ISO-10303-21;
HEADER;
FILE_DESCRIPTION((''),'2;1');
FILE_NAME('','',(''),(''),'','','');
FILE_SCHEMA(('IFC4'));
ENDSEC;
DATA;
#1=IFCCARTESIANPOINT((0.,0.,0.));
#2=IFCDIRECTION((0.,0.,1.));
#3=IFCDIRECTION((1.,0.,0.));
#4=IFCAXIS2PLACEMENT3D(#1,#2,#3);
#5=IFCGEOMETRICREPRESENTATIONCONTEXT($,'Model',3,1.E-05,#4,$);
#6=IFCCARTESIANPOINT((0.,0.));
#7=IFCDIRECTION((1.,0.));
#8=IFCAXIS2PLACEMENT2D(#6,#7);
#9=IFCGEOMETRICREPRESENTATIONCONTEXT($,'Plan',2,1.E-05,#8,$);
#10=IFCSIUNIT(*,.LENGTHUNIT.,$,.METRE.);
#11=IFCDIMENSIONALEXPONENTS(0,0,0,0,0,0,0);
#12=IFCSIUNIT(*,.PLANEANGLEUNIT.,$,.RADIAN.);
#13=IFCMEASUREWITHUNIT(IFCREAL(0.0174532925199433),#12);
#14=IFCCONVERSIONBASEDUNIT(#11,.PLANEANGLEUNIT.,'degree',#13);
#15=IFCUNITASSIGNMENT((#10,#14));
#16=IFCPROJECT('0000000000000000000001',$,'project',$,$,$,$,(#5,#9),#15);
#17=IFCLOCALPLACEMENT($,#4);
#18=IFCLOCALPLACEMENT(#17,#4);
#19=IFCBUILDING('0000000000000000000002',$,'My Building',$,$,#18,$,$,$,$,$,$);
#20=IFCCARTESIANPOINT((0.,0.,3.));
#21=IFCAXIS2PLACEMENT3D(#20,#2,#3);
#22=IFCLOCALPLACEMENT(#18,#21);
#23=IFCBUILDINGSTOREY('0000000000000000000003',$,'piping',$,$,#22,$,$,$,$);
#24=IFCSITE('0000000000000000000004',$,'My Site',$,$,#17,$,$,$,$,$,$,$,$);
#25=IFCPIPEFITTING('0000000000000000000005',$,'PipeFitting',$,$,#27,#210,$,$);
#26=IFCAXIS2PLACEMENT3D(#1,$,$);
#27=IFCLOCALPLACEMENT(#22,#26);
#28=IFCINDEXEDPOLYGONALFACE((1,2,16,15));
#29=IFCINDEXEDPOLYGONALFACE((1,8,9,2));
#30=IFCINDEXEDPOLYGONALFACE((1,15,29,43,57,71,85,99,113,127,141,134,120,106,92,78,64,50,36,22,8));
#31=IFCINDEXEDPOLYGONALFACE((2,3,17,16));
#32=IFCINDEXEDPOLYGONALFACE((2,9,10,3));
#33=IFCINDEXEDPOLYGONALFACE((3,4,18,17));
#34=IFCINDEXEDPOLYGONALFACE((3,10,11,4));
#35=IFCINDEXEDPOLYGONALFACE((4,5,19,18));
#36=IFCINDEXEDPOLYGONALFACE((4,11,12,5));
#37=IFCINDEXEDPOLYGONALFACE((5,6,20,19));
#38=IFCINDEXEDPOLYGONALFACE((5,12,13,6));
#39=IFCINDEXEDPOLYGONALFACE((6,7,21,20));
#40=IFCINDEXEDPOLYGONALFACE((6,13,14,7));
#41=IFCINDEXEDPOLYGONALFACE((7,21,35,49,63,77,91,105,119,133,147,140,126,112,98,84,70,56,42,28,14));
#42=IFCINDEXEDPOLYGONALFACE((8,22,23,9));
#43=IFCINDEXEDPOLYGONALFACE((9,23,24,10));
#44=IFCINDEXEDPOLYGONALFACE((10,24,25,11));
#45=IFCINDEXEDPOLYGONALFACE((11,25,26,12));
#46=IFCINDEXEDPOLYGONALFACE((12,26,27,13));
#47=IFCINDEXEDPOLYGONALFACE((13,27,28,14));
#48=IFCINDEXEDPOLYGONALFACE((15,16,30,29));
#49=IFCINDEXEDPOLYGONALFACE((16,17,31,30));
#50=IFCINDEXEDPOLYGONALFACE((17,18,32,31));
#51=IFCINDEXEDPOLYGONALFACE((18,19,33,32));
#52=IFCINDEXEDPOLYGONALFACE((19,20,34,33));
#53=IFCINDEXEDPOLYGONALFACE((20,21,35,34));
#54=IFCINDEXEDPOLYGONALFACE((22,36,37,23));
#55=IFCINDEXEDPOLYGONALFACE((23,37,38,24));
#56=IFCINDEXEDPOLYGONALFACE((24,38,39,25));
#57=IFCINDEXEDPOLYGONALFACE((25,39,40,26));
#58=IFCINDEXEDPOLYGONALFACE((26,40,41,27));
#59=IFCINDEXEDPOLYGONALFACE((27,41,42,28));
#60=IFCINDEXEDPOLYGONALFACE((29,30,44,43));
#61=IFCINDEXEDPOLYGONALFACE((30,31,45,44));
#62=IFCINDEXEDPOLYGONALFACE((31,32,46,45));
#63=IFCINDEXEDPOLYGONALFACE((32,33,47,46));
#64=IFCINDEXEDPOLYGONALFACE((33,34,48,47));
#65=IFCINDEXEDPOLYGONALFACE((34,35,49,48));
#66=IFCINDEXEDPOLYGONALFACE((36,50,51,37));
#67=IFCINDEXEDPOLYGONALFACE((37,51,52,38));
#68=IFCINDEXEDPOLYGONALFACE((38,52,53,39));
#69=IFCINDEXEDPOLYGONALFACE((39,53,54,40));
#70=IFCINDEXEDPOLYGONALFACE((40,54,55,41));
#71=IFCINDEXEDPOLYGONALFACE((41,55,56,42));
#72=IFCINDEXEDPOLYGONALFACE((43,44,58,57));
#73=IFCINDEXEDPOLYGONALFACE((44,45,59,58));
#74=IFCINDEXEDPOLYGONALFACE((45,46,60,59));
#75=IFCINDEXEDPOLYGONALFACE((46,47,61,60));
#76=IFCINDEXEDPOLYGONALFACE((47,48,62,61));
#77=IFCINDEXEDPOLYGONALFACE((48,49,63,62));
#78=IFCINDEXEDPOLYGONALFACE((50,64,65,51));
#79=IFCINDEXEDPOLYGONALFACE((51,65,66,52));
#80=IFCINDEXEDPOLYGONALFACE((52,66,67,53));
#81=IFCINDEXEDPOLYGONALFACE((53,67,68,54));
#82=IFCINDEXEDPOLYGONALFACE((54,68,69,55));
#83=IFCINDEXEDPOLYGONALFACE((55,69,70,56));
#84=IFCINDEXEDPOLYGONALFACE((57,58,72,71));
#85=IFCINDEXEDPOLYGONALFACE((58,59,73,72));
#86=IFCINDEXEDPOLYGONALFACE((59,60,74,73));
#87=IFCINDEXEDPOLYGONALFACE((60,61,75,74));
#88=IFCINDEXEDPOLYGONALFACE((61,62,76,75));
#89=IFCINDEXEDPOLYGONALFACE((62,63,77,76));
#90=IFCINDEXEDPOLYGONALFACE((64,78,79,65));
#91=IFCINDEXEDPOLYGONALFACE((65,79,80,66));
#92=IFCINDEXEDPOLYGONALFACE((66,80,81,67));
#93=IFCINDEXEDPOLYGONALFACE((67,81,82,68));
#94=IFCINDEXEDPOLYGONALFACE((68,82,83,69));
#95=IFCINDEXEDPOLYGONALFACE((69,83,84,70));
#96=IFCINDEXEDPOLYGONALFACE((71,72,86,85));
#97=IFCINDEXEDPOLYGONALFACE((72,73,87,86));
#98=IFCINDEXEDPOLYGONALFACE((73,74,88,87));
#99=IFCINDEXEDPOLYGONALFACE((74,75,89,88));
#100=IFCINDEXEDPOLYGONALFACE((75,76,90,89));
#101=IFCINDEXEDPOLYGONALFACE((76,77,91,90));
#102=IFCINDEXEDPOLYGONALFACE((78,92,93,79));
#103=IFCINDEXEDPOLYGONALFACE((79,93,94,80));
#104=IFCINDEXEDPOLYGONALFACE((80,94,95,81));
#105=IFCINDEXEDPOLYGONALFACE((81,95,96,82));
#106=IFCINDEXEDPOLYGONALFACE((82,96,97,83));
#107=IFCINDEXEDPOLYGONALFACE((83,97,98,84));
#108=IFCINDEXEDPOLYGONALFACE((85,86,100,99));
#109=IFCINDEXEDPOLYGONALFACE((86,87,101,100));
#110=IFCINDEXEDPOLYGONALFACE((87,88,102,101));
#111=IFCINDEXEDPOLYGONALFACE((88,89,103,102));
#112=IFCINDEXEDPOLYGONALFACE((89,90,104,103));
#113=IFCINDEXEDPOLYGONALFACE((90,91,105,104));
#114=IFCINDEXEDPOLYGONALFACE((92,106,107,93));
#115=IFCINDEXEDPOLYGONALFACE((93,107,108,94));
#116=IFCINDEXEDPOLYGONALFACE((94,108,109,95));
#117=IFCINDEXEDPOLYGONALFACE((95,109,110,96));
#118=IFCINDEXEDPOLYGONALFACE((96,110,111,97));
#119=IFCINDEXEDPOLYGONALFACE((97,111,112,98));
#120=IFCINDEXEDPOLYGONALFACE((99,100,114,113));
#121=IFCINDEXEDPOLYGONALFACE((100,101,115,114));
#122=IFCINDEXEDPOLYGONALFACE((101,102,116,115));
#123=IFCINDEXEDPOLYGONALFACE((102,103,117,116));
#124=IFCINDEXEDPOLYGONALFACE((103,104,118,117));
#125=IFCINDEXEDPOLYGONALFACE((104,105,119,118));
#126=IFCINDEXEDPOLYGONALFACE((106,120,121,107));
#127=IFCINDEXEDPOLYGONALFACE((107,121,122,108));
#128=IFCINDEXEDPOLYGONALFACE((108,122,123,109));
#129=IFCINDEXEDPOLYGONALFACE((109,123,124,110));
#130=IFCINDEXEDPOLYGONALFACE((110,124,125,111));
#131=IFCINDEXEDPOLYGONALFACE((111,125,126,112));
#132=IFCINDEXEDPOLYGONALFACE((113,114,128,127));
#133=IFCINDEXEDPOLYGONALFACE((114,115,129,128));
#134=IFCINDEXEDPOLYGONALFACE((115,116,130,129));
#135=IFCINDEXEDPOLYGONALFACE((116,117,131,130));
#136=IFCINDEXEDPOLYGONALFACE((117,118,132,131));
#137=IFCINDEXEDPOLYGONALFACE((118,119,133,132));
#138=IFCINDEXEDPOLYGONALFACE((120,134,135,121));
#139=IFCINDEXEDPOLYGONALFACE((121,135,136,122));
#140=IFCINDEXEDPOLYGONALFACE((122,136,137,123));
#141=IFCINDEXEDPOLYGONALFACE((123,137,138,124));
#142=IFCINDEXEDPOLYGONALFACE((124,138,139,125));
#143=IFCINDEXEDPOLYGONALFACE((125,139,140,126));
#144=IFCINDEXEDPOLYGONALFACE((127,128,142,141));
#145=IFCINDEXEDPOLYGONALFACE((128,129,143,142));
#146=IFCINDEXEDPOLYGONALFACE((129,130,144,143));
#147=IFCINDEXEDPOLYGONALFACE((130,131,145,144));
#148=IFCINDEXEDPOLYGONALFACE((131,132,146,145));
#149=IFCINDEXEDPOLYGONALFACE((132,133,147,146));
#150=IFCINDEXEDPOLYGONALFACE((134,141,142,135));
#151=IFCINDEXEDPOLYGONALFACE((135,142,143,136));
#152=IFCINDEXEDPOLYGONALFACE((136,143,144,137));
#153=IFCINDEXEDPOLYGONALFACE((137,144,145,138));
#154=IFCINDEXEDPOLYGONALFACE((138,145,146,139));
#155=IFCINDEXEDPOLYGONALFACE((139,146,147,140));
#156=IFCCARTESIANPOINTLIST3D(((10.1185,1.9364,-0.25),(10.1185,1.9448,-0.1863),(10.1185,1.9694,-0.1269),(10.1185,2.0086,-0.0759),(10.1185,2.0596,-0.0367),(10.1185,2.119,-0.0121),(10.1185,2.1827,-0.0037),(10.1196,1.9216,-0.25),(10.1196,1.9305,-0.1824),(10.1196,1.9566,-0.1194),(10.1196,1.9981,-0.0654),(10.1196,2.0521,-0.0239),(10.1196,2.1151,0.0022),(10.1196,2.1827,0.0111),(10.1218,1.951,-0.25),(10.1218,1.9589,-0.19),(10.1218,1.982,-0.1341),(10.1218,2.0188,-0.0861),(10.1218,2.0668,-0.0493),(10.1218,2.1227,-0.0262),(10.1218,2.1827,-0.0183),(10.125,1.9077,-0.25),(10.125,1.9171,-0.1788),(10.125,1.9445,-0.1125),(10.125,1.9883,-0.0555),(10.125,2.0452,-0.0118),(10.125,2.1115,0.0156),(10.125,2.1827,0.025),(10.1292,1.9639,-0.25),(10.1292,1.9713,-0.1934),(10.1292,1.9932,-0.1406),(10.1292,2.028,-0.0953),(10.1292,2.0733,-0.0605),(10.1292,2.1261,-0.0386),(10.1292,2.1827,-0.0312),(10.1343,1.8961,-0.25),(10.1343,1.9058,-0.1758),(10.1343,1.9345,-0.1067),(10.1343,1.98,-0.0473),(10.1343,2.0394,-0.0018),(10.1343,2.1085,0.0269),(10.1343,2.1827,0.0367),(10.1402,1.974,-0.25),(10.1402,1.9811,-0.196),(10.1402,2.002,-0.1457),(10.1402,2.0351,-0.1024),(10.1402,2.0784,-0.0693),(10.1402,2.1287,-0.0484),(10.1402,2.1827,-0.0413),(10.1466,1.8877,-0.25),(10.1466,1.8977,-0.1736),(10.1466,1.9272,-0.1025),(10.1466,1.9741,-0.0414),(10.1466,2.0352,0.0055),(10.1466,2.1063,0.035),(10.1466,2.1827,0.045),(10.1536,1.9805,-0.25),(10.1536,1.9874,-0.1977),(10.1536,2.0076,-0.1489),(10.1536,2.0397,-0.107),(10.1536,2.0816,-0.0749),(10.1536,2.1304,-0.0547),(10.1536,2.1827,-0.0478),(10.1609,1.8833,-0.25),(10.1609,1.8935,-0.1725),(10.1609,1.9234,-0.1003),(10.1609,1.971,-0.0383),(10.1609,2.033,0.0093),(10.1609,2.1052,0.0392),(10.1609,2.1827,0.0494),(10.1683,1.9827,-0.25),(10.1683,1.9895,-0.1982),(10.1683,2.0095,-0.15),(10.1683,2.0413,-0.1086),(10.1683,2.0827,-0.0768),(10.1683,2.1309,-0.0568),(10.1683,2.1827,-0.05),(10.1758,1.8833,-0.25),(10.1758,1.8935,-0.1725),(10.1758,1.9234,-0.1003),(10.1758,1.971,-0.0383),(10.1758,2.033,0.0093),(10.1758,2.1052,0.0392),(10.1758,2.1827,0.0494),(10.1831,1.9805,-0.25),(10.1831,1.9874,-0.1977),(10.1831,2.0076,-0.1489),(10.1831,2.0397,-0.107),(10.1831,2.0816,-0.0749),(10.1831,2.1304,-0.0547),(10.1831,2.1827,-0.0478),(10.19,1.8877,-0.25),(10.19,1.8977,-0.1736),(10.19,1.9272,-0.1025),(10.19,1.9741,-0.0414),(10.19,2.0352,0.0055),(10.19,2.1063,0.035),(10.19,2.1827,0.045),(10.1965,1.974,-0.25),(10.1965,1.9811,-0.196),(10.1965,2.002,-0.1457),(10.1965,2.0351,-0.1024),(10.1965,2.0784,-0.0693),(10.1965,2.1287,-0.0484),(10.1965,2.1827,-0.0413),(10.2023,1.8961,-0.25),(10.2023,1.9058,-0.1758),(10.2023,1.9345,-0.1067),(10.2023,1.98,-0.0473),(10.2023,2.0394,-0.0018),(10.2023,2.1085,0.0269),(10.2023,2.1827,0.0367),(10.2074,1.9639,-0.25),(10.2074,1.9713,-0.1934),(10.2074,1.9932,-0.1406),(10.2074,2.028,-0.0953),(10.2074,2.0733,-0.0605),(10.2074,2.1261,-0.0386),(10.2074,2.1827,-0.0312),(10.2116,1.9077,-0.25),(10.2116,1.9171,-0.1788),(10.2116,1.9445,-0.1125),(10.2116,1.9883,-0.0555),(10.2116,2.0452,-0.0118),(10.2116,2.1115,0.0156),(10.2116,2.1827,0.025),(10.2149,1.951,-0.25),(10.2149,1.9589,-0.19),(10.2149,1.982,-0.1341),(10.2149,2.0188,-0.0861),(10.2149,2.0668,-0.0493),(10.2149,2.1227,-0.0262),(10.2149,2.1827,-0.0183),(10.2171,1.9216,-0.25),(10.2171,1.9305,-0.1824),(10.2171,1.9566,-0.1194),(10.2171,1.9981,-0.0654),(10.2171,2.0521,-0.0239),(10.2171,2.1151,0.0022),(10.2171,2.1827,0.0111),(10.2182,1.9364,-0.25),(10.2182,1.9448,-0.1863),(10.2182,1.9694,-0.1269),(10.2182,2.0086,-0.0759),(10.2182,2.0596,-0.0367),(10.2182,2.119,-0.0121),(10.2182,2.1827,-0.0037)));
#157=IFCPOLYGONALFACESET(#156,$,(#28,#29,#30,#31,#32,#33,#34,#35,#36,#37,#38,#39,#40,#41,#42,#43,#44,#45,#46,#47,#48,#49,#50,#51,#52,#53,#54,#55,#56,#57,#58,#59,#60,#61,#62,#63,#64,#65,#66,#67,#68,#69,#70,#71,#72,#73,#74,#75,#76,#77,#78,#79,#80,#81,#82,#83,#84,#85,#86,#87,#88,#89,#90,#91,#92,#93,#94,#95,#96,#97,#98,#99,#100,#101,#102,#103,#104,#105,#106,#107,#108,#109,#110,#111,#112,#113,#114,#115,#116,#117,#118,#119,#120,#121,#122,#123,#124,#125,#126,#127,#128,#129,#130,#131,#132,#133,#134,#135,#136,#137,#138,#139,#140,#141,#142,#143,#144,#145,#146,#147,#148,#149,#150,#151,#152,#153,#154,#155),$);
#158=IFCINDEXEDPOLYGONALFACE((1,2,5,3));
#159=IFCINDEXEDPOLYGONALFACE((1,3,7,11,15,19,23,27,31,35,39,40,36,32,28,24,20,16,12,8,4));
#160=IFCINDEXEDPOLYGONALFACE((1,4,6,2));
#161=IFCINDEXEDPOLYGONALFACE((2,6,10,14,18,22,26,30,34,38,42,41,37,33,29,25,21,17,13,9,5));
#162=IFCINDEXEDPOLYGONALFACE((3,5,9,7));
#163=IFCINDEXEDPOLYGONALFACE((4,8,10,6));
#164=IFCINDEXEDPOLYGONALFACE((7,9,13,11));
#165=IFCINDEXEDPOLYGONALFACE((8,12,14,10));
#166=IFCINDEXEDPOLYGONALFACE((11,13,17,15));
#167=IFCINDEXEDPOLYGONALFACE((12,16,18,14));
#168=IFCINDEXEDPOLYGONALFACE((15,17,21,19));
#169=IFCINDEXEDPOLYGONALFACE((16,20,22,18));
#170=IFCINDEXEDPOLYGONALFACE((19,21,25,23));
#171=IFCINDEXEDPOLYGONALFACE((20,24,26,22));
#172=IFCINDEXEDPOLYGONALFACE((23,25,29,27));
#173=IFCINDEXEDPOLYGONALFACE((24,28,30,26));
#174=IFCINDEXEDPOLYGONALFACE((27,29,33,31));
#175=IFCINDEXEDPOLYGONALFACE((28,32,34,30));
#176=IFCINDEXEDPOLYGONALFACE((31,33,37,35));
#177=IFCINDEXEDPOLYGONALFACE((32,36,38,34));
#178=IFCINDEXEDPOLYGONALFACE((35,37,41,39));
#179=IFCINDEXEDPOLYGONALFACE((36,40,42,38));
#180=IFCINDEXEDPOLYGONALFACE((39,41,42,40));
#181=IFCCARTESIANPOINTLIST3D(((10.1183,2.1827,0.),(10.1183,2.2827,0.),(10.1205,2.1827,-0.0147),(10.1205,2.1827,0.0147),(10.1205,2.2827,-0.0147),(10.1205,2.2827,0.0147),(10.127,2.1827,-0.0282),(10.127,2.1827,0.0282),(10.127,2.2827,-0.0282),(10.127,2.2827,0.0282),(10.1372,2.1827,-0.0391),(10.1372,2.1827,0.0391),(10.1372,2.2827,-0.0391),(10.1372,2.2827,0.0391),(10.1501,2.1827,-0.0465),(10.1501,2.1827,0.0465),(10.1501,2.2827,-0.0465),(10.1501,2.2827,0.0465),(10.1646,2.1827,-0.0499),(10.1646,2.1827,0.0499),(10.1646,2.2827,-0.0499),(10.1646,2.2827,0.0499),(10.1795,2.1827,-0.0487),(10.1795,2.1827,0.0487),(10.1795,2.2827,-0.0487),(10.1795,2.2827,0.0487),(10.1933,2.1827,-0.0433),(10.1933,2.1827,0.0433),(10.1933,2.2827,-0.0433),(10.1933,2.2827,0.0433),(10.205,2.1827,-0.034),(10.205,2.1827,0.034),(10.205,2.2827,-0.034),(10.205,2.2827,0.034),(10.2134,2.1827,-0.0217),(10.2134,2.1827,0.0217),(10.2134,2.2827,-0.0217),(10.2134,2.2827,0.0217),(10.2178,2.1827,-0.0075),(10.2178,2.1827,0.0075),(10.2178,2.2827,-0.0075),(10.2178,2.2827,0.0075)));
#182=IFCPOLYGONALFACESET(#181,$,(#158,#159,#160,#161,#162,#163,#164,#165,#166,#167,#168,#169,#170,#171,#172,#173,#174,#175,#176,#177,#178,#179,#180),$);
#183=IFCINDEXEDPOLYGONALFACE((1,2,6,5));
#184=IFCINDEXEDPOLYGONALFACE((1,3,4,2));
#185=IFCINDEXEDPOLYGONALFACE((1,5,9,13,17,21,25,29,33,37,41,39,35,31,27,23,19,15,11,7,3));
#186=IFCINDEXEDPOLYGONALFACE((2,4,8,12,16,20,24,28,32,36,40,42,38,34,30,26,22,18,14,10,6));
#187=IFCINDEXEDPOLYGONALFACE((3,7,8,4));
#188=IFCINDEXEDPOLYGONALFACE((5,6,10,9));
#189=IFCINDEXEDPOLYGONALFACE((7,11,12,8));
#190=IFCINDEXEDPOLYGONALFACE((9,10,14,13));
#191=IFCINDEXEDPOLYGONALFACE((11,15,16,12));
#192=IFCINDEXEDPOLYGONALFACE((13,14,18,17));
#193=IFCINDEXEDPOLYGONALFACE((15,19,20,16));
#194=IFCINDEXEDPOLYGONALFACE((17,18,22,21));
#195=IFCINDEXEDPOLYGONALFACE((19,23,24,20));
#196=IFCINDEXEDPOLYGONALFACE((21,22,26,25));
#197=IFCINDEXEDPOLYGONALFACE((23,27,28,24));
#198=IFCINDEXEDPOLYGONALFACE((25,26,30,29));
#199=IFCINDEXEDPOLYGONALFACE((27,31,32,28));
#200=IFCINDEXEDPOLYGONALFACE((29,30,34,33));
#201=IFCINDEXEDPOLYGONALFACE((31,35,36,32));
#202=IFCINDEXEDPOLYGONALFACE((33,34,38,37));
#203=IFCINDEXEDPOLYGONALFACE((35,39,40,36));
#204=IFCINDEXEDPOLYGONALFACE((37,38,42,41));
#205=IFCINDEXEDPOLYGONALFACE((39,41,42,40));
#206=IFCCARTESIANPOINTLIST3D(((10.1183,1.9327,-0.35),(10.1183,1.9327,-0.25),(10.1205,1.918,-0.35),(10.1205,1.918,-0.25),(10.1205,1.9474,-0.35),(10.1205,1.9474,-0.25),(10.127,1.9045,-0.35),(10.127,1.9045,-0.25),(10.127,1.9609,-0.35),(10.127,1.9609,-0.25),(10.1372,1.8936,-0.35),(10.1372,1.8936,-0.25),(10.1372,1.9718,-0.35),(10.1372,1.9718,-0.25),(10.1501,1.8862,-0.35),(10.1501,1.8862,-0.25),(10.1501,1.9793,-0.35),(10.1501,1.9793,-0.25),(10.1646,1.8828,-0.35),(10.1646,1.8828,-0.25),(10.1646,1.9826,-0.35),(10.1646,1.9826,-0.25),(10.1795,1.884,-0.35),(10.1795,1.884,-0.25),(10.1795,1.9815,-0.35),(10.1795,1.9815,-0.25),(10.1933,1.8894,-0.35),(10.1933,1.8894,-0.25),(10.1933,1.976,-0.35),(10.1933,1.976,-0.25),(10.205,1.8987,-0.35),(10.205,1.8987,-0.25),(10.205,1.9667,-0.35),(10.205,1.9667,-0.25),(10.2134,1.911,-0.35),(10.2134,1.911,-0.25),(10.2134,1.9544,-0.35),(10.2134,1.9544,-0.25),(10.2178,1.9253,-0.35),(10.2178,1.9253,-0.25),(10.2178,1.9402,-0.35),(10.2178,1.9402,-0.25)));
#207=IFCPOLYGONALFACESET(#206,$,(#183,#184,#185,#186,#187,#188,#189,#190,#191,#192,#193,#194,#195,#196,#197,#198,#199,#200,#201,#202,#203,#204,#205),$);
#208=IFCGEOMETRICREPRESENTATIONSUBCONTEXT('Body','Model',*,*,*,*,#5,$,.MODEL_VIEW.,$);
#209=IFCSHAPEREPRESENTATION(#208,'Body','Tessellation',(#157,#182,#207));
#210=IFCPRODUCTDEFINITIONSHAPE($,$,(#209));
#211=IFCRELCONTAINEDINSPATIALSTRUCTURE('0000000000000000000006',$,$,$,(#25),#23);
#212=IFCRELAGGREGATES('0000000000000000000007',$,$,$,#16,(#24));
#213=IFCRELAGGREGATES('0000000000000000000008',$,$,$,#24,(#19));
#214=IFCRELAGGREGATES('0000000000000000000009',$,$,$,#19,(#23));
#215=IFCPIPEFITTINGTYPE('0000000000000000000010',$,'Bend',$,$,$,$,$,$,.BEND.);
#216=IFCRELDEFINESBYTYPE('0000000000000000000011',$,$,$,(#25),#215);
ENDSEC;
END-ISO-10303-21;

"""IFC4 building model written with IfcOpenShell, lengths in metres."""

from ifc_helpers import new_model, entity, si_unit, converted_unit, frame, origin_with_axes, origin_2d_with_axis, place, context, subcontext, project, spatial, circle, extrude, source, transform, mapped, type_object, type_shapes, element, save


model = new_model("IFC4")

# Units and contexts
model_context = context("Model", 3, precision=1e-05, world=origin_with_axes())
plan_context = context("Plan", 2, precision=1e-05, world=origin_2d_with_axis())
body_context = subcontext(model_context, "Body", "Model", "MODEL_VIEW")
ifc_project = project(units=[si_unit("LENGTHUNIT", "METRE"), converted_unit("PLANEANGLEUNIT", "degree", entity("IfcReal", 0.0174532925199433), si_unit("PLANEANGLEUNIT", "RADIAN"), dimensions=[0, 0, 0, 0, 0, 0, 0])], contexts=[model_context, plan_context])

# Site, building, storey
site_placement = place(None, origin_with_axes())
site = spatial("IfcSite", under=ifc_project, at=site_placement, Name="My Site")
building_placement = place(site_placement, origin_with_axes())
building = spatial("IfcBuilding", under=site, at=building_placement, Name="My Building")
storey_placement = place(building_placement, frame((0.0, 0.0, 3.0), z_axis=(0.0, 0.0, 1.0), x_axis=(1.0, 0.0, 0.0)))
storey = spatial("IfcBuildingStorey", under=building, at=storey_placement, Name="piping")

# Pipe fitting
pipe_fitting_type = type_object("IfcPipeFittingType", Name="Bend", PredefinedType="BEND")
shared_shape = source(origin_with_axes(), body_context, "Body", "SolidModel", [
    entity("IfcSweptDiskSolid", entity("IfcIndexedPolyCurve", entity("IfcCartesianPointList3D", [[0.0, 0.0, -0.1], [0.0, -0.0732, -0.2768], [0.0, -0.25, -0.35]]), [entity("IfcArcIndex", [1, 2, 3])]), 0.05),
    extrude(circle(Radius=0.05), origin_with_axes(), (0.0, 0.0, -1.0), 0.1),
    extrude(circle(Radius=0.05), frame((0.0, -0.25, -0.35), z_axis=(0.0, -1.0, 0.0), x_axis=(1.0, 0.0, 0.0)), (0.0, 0.0, 1.0), 0.1),
])
type_shapes(pipe_fitting_type, [shared_shape])
for number, where, z_axis, x_axis, name in (
    (1, (10.1683, 2.2827, 0.0), (0.0, 1.0, 0.0), (-1.0, 0.0, 0.0), "PipeFitting"),
):
    element("IfcPipeFitting", number, at=place(storey_placement, frame(where, z_axis=z_axis, x_axis=x_axis)), inside=storey, type_object=pipe_fitting_type, Name=name, context=body_context, shape_type="MappedRepresentation", body=[
        mapped(shared_shape, transform((0.0, 0.0, 0.0), x_axis=(1.0, 0.0, 0.0), y_axis=(0.0, 1.0, 0.0), z_axis=(0.0, 0.0, 1.0), scale=1.0)),
    ])

save(model, "model.ifc")
